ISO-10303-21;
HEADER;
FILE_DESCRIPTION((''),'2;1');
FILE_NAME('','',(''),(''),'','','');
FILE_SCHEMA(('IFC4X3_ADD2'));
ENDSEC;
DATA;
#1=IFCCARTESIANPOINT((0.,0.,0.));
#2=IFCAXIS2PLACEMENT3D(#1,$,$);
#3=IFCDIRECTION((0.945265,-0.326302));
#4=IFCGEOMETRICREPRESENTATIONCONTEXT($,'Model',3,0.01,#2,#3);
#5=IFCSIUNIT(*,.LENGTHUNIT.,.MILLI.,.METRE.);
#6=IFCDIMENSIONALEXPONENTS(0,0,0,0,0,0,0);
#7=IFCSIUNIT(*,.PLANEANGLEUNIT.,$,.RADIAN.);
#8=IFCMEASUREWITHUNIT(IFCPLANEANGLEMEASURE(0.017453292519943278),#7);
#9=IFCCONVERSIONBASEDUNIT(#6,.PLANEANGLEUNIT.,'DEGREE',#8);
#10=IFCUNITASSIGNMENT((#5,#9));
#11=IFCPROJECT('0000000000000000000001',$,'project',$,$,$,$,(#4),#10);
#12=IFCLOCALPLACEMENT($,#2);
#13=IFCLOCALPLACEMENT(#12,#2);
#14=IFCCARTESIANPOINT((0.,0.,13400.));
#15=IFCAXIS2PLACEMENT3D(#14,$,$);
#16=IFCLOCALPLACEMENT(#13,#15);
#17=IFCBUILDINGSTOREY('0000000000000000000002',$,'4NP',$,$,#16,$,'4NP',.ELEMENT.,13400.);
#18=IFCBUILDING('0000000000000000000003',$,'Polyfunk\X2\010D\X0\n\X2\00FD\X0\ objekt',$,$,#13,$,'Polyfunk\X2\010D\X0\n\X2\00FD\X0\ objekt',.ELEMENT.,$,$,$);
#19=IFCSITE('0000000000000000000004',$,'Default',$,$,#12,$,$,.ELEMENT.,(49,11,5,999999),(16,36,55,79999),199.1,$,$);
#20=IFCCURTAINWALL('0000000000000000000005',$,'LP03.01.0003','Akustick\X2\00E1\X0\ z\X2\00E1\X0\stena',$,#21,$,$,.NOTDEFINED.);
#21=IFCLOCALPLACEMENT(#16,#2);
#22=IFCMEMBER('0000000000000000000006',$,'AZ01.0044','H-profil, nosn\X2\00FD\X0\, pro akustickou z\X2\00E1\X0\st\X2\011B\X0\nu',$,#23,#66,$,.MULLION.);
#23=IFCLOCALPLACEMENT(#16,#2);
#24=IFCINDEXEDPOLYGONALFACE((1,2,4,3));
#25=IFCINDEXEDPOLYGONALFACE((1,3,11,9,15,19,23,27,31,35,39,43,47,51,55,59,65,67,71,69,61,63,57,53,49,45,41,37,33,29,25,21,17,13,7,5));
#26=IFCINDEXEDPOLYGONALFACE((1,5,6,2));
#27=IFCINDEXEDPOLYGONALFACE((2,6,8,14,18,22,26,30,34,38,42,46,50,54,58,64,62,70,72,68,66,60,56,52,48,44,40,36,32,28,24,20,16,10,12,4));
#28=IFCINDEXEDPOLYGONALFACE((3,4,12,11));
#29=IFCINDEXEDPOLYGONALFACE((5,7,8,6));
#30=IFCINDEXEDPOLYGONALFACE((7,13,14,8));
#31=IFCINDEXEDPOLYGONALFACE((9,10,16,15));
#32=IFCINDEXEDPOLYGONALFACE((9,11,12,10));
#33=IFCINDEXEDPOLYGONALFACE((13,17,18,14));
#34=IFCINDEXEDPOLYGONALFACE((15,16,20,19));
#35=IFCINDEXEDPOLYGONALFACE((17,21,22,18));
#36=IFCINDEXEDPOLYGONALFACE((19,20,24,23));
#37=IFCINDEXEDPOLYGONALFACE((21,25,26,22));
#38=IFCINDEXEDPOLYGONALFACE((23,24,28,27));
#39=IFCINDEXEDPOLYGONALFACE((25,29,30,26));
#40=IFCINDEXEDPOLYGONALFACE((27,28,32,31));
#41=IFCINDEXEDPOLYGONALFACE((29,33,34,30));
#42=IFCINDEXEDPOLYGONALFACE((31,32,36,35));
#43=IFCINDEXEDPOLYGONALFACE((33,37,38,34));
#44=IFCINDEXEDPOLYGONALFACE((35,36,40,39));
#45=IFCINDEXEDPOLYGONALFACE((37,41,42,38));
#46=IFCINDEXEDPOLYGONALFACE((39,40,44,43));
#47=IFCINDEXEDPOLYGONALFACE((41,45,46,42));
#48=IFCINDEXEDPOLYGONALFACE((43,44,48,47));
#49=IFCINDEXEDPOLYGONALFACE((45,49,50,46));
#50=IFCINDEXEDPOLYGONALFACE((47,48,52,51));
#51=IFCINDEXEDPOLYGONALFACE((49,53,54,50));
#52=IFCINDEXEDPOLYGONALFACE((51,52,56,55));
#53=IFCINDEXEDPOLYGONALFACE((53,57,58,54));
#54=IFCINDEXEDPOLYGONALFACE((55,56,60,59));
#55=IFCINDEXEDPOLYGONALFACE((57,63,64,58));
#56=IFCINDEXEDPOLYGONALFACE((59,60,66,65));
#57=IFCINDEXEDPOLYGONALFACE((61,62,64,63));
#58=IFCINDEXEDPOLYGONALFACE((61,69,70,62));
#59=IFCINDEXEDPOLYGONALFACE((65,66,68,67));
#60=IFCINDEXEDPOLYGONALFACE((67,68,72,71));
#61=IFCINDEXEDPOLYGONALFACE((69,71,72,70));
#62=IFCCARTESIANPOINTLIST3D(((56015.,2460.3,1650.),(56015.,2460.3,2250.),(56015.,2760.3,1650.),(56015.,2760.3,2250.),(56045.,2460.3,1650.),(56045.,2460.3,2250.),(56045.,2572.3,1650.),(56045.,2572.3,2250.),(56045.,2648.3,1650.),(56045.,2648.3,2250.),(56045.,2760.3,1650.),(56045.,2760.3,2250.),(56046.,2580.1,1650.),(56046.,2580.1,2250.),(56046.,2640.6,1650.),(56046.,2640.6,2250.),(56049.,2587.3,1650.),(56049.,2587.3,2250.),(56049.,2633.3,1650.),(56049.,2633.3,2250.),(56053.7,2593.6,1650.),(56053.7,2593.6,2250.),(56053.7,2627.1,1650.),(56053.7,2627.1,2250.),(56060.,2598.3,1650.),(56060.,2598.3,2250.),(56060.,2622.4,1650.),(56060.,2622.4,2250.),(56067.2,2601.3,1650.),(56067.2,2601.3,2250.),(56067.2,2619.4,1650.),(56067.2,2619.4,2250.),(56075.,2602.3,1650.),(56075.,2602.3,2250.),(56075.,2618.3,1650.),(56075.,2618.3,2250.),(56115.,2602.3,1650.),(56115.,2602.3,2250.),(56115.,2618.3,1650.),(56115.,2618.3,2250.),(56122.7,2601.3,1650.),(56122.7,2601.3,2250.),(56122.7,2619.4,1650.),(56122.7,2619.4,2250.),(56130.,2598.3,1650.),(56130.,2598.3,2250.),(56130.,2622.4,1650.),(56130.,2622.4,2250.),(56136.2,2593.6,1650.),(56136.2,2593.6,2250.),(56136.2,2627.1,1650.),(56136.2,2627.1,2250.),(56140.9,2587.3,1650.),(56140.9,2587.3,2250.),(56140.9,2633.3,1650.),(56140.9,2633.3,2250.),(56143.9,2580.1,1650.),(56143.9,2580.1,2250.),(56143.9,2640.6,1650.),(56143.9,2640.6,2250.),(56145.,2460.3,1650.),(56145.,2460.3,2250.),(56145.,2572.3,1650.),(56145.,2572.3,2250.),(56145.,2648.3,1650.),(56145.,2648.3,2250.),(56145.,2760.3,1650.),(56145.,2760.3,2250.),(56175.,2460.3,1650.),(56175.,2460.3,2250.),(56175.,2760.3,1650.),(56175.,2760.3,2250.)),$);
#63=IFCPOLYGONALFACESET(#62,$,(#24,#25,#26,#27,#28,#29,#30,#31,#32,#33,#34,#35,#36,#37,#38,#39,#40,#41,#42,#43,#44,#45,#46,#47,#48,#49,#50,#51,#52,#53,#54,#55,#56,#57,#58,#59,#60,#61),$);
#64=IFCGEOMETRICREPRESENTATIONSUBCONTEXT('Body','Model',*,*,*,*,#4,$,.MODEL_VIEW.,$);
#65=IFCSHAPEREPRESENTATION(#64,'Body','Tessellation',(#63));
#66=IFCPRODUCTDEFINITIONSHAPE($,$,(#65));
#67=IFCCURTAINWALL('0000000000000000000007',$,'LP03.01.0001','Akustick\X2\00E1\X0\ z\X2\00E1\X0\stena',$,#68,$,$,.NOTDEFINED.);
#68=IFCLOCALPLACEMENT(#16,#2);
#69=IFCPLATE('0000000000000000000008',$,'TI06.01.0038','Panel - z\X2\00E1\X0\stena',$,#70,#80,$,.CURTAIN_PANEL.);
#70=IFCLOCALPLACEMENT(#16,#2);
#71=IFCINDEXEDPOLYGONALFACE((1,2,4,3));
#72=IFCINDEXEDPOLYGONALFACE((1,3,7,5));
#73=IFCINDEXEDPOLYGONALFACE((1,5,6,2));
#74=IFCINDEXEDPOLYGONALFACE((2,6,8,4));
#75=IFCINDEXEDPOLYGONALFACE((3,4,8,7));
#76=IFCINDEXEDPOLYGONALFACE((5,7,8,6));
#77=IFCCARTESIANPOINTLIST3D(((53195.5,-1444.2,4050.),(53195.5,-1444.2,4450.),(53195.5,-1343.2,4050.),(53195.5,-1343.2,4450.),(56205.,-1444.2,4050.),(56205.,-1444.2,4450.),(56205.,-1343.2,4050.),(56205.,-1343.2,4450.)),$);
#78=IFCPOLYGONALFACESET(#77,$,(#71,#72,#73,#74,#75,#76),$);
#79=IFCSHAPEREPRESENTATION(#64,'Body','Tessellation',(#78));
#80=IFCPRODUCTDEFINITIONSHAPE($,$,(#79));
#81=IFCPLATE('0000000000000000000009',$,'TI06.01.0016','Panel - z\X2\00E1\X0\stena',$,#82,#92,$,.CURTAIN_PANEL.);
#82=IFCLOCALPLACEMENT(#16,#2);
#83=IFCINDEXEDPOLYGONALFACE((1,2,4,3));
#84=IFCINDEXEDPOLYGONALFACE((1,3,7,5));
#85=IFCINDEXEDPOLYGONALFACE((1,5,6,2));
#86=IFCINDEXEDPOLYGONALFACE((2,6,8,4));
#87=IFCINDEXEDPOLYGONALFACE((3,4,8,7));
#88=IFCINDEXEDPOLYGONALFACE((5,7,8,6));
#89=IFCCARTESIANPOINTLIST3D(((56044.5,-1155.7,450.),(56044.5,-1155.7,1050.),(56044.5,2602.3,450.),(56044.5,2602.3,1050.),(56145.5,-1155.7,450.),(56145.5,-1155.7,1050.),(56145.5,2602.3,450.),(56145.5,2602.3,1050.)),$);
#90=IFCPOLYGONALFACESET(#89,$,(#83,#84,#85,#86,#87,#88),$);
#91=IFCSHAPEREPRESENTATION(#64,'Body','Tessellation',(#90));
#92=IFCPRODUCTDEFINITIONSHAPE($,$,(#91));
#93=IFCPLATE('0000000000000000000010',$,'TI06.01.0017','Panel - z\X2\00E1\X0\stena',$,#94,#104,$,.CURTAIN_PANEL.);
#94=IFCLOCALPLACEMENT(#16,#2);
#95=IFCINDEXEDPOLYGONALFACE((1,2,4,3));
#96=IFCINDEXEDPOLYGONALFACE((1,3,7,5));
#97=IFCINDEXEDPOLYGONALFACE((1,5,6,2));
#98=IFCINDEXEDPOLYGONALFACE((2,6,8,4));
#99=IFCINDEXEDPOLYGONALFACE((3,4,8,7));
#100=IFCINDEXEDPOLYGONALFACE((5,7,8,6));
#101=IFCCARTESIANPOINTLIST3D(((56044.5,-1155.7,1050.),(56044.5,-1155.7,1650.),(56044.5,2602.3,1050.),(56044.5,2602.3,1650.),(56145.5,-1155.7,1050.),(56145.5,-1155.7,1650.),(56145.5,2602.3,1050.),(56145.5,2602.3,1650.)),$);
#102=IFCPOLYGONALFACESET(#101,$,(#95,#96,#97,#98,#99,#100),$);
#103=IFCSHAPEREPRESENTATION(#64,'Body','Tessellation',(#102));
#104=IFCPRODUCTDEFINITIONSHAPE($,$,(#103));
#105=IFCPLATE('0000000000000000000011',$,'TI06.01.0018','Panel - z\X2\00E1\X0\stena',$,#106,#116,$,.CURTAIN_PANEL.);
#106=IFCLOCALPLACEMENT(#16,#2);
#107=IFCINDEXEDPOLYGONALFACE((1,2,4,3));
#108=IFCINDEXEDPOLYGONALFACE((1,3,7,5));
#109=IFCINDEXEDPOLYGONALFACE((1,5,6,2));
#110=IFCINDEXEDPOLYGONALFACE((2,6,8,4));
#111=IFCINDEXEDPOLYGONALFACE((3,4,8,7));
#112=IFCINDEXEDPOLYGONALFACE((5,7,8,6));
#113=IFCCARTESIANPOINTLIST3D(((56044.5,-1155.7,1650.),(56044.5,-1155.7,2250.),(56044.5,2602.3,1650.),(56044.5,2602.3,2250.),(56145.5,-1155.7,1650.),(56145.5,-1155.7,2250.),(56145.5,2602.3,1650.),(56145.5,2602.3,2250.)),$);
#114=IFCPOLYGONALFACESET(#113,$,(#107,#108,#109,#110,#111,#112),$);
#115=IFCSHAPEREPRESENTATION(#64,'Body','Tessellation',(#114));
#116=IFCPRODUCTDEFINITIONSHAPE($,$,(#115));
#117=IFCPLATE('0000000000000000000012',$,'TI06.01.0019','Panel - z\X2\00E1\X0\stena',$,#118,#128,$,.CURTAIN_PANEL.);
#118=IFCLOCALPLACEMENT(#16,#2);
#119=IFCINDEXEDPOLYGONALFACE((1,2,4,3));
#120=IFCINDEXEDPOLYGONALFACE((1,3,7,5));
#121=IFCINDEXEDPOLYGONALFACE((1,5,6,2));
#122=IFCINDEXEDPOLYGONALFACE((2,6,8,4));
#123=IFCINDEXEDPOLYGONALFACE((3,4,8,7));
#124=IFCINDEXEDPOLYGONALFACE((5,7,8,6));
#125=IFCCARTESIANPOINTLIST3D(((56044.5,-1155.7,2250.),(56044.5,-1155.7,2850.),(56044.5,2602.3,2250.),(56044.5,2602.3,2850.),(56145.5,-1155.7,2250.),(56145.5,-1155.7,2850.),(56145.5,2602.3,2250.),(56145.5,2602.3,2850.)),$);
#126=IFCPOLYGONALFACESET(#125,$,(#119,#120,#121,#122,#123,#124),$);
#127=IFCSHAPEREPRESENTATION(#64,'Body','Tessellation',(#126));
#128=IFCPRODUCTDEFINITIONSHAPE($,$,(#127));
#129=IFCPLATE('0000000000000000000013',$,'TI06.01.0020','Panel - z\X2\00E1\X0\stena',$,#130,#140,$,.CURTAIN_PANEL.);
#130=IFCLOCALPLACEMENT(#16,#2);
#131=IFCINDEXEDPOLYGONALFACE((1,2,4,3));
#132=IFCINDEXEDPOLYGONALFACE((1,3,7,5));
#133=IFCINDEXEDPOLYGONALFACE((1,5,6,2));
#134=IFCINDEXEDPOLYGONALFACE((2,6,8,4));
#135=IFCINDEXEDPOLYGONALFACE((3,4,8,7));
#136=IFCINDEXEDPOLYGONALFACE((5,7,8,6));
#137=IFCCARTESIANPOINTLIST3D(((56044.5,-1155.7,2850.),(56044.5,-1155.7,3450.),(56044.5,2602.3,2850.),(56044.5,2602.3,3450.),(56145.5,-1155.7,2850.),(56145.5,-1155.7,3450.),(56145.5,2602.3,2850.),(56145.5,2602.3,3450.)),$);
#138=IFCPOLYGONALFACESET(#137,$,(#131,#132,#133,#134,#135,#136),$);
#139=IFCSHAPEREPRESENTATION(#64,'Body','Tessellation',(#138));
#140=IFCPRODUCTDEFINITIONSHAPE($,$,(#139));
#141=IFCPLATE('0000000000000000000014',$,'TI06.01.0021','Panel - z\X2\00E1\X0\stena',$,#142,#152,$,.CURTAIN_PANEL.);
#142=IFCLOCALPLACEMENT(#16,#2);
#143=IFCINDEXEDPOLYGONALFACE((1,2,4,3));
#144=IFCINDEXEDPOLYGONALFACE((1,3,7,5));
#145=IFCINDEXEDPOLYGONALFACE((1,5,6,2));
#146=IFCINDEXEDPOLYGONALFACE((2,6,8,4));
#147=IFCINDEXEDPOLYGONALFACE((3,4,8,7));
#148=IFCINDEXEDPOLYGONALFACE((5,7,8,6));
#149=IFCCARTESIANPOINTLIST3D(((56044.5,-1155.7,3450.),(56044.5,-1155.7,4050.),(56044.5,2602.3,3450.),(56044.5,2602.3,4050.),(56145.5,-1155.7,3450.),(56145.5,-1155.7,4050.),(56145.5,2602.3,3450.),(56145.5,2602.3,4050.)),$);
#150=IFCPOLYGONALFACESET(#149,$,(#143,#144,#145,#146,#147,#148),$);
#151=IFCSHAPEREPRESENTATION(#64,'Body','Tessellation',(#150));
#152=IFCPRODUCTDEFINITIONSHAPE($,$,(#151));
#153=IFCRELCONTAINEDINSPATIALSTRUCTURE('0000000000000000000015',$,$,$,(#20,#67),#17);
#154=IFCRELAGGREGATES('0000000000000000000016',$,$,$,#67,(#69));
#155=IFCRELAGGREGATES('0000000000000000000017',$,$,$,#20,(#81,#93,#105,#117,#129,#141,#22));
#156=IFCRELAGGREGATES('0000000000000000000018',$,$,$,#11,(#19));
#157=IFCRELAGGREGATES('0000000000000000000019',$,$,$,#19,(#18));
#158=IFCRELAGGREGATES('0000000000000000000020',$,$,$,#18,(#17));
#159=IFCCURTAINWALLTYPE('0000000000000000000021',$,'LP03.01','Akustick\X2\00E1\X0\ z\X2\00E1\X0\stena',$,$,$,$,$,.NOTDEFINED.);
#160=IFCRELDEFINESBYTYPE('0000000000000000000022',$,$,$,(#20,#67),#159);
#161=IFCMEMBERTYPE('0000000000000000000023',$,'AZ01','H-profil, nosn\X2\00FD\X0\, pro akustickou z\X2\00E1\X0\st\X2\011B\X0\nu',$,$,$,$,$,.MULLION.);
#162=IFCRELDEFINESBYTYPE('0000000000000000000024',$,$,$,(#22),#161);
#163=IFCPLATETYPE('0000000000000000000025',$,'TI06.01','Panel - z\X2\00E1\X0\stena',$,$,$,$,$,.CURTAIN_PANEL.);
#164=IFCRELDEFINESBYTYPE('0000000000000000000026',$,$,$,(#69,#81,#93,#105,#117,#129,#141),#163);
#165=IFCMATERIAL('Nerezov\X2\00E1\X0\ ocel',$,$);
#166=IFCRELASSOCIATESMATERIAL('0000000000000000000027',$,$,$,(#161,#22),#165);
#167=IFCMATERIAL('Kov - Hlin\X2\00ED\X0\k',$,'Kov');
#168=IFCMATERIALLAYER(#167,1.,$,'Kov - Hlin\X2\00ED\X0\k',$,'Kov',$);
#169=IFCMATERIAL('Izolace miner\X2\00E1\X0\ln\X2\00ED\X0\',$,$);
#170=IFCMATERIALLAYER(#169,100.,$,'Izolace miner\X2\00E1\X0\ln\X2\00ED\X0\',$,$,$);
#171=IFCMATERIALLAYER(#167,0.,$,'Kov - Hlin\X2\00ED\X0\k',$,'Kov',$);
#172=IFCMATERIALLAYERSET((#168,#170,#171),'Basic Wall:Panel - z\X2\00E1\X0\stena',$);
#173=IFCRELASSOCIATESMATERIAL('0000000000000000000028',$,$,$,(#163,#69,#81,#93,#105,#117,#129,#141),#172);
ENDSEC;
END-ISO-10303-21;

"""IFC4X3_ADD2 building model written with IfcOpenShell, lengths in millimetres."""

from ifc_helpers import new_model, entity, si_unit, converted_unit, direction, frame, frame_2d, origin, place, context, subcontext, project, spatial, polyline, circle_curve, parameter, trimmed, segment, composite_curve, rectangle, outline, extrude, source, transform, mapped, material, layer, layer_set, layer_usage, material_profile, profile_set, profile_usage, type_object, element, aggregate, save


model = new_model("IFC4X3_ADD2")

# Units and contexts
model_context = context("Model", 3, precision=0.01, world=origin(), true_north=direction((0.945265, -0.326302)))
body_context = subcontext(model_context, "Body", "Model", "MODEL_VIEW")
ifc_project = project(units=[si_unit("LENGTHUNIT", "METRE", prefix="MILLI"), converted_unit("PLANEANGLEUNIT", "DEGREE", entity("IfcPlaneAngleMeasure", 0.017453292519943278), si_unit("PLANEANGLEUNIT", "RADIAN"), dimensions=[0, 0, 0, 0, 0, 0, 0])], contexts=[model_context])

# Site, building, storey
site_placement = place(None, origin())
site = spatial("IfcSite", under=ifc_project, at=site_placement, Name="Default", CompositionType="ELEMENT", RefLatitude=(49, 11, 5, 999999), RefLongitude=(16, 36, 55, 79999), RefElevation=199.1)
building_placement = place(site_placement, origin())
building = spatial("IfcBuilding", under=site, at=building_placement, Name="Polyfunkčný objekt", LongName="Polyfunkčný objekt", CompositionType="ELEMENT")
storey_placement = place(building_placement, frame((0.0, 0.0, 13400.0)))
storey = spatial("IfcBuildingStorey", under=building, at=storey_placement, Name="4NP", LongName="4NP", CompositionType="ELEMENT", Elevation=13400.0)

# Curtain wall, member
curtain_wall_type = type_object("IfcCurtainWallType", Name="LP03.01", Description="Akustická zástena", PredefinedType="NOTDEFINED")
curtain_wall_1_placement = place(storey_placement, frame((0.0, 0.0, -13400.0)))
curtain_wall_1 = element("IfcCurtainWall", 1, at=curtain_wall_1_placement, inside=storey, type_object=curtain_wall_type, Name="LP03.01.0003", Description="Akustická zástena", PredefinedType="NOTDEFINED")
ifc_material_1 = material(Name="Nerezová ocel")
ifc_material_profile = material_profile(ifc_material_1, outline(composite_curve([segment(polyline([(50.0, -150.0), (80.0, -150.0)]), True, "CONTINUOUS"), segment(polyline([(80.0, -150.0), (80.0, 150.0)]), True, "CONTINUOUS"), segment(polyline([(80.0, 150.0), (50.0, 150.0)]), True, "CONTINUOUS"), segment(polyline([(50.0, 150.0), (50.0, 38.0)]), True, "CONTINUOUS"), segment(trimmed(circle_curve(frame_2d((20.0, 38.0), x_axis=(0.0, 1.0)), 30.0), [parameter(180.0)], [parameter(270.0)], True, "PARAMETER"), False, "CONTINUOUS"), segment(polyline([(20.0, 8.0), (-20.0, 8.0)]), True, "CONTINUOUS"), segment(trimmed(circle_curve(frame_2d((-20.0, 38.0), x_axis=(0.0, 1.0)), 30.0), [parameter(90.0)], [parameter(180.0)], True, "PARAMETER"), False, "CONTINUOUS"), segment(polyline([(-50.0, 38.0), (-50.0, 150.0)]), True, "CONTINUOUS"), segment(polyline([(-50.0, 150.0), (-80.0, 150.0)]), True, "CONTINUOUS"), segment(polyline([(-80.0, 150.0), (-80.0, -150.0)]), True, "CONTINUOUS"), segment(polyline([(-80.0, -150.0), (-50.0, -150.0)]), True, "CONTINUOUS"), segment(polyline([(-50.0, -150.0), (-50.0, -38.0)]), True, "CONTINUOUS"), segment(trimmed(circle_curve(frame_2d((-20.0, -38.0), x_axis=(0.0, 1.0)), 30.0), [parameter(0.0)], [parameter(90.0)], True, "PARAMETER"), False, "CONTINUOUS"), segment(polyline([(-20.0, -8.0), (20.0, -8.0)]), True, "CONTINUOUS"), segment(trimmed(circle_curve(frame_2d((20.0, -38.0), x_axis=(0.0, 1.0)), 30.0), [parameter(270.0)], [parameter(0.0)], True, "PARAMETER"), False, "CONTINUOUS"), segment(polyline([(50.0, -38.0), (50.0, -150.0)]), True, "CONTINUOUS")], self_intersect=False)), Name="Profil zástena")
ifc_profile_set = profile_set([ifc_material_profile], Name="Profil zástena")
ifc_profile_usage = profile_usage(ifc_profile_set)
member_type = type_object("IfcMemberType", Name="AZ01", Description="H-profil, nosný, pro akustickou zástěnu", PredefinedType="MULLION", material=ifc_profile_set)
shared_shape_1 = source(origin(), body_context, "Body", "SweptSolid", [
    extrude(outline(composite_curve([segment(polyline([(-150.0, -50.0), (-150.0, -80.0)]), True, "CONTINUOUS"), segment(polyline([(-150.0, -80.0), (150.0, -80.0)]), True, "CONTINUOUS"), segment(polyline([(150.0, -80.0), (150.0, -50.0)]), True, "CONTINUOUS"), segment(polyline([(150.0, -50.0), (38.0, -50.0)]), True, "CONTINUOUS"), segment(trimmed(circle_curve(frame_2d((38.0, -20.0), x_axis=(1.0, 0.0)), 30.0), [parameter(180.0)], [parameter(270.0)], True, "PARAMETER"), False, "CONTINUOUS"), segment(polyline([(8.0, -20.0), (8.0, 20.0)]), True, "CONTINUOUS"), segment(trimmed(circle_curve(frame_2d((38.0, 20.0), x_axis=(1.0, 0.0)), 30.0), [parameter(90.0)], [parameter(180.0)], True, "PARAMETER"), False, "CONTINUOUS"), segment(polyline([(38.0, 50.0), (150.0, 50.0)]), True, "CONTINUOUS"), segment(polyline([(150.0, 50.0), (150.0, 80.0)]), True, "CONTINUOUS"), segment(polyline([(150.0, 80.0), (-150.0, 80.0)]), True, "CONTINUOUS"), segment(polyline([(-150.0, 80.0), (-150.0, 50.0)]), True, "CONTINUOUS"), segment(polyline([(-150.0, 50.0), (-38.0, 50.0)]), True, "CONTINUOUS"), segment(trimmed(circle_curve(frame_2d((-38.0, 20.0), x_axis=(1.0, 0.0)), 30.0), [parameter(0.0)], [parameter(90.0)], True, "PARAMETER"), False, "CONTINUOUS"), segment(polyline([(-8.0, 20.0), (-8.0, -20.0)]), True, "CONTINUOUS"), segment(trimmed(circle_curve(frame_2d((-38.0, -20.0), x_axis=(1.0, 0.0)), 30.0), [parameter(270.0)], [parameter(0.0)], True, "PARAMETER"), False, "CONTINUOUS"), segment(polyline([(-38.0, -50.0), (-150.0, -50.0)]), True, "CONTINUOUS")], self_intersect=False)), frame((0.0, 0.0, -600.0), z_axis=(0.0, 0.0, -1.0), x_axis=(1.0, 0.0, 0.0)), (0.0, 0.0, -1.0), 600.0),
])
member_1_placement = place(curtain_wall_1_placement, frame((56095.0, 2610.3, 15050.0), z_axis=(0.0, 0.0, -1.0), x_axis=(0.0, 1.0, 0.0)))
member_1 = element("IfcMember", 2, at=member_1_placement, type_object=member_type, material=ifc_profile_usage, Name="AZ01.0044", Description="H-profil, nosný, pro akustickou zástěnu", PredefinedType="MULLION", context=body_context, shape_type="MappedRepresentation", body=[
    mapped(shared_shape_1, transform((0.0, 0.0, 0.0), scale=1.0)),
])

# Curtain wall, plate
curtain_wall_2_placement = place(storey_placement, frame((0.0, 0.0, -13400.0)))
curtain_wall_2 = element("IfcCurtainWall", 3, at=curtain_wall_2_placement, inside=storey, type_object=curtain_wall_type, Name="LP03.01.0001", Description="Akustická zástena", PredefinedType="NOTDEFINED")
ifc_material_2 = material(Name="Kov - Hliník", Category="Kov")
ifc_layer_1 = layer(ifc_material_2, 1.0, Name="Kov - Hliník", Category="Kov")
ifc_material_3 = material(Name="Izolace minerální")
ifc_layer_2 = layer(ifc_material_3, 100.0, Name="Izolace minerální")
ifc_layer_3 = layer(ifc_material_2, 0.0, Name="Kov - Hliník", Category="Kov")
ifc_layer_set_1 = layer_set([ifc_layer_1, ifc_layer_2, ifc_layer_3], Name="Basic Wall:Panel - zástena")
ifc_layer_usage_1 = layer_usage(ifc_layer_set_1, "AXIS2", "POSITIVE", -50.5)
plate_type = type_object("IfcPlateType", Name="TI06.01", Description="Panel - zástena", PredefinedType="CURTAIN_PANEL", material=ifc_layer_set_1)
plate_1_placement = place(storey_placement, frame((53195.5, -1393.7, 4050.0)))
plate_1 = element("IfcPlate", 4, at=plate_1_placement, type_object=plate_type, material=ifc_layer_usage_1, Name="TI06.01.0038", Description="Panel - zástena", PredefinedType="CURTAIN_PANEL", context=body_context, shape_type="SweptSolid", body=[
    extrude(rectangle(XDim=101.0, YDim=3009.5, at=frame_2d((0.0, 0.0), x_axis=(1.0, 0.0))), frame((1504.7, 0.0, 0.0), z_axis=(0.0, 0.0, 1.0), x_axis=(0.0, 1.0, 0.0)), (0.0, 0.0, 1.0), 400.0),
])
aggregate(curtain_wall_2, [plate_1])

# Plates
ifc_layer_usage_2 = layer_usage(ifc_layer_set_1, "AXIS2", "NEGATIVE", 50.5)
plate_2_placement = place(storey_placement, frame((56095.0, -1155.7, 450.0), z_axis=(0.0, 0.0, 1.0), x_axis=(0.0, 1.0, 0.0)))
plate_2 = element("IfcPlate", 5, at=plate_2_placement, type_object=plate_type, material=ifc_layer_usage_2, Name="TI06.01.0016", Description="Panel - zástena", PredefinedType="CURTAIN_PANEL", context=body_context, shape_type="SweptSolid", body=[
    extrude(rectangle(XDim=101.0, YDim=3758.1, at=frame_2d((0.0, 0.0), x_axis=(1.0, 0.0))), frame((1879.0, 0.0, 0.0), z_axis=(0.0, 0.0, 1.0), x_axis=(0.0, 1.0, 0.0)), (0.0, 0.0, 1.0), 600.0),
])
ifc_layer_usage_3 = layer_usage(ifc_layer_set_1, "AXIS2", "NEGATIVE", 50.5)
plate_3_placement = place(storey_placement, frame((56095.0, -1155.7, 1050.0), z_axis=(0.0, 0.0, 1.0), x_axis=(0.0, 1.0, 0.0)))
plate_3 = element("IfcPlate", 6, at=plate_3_placement, type_object=plate_type, material=ifc_layer_usage_3, Name="TI06.01.0017", Description="Panel - zástena", PredefinedType="CURTAIN_PANEL", context=body_context, shape_type="SweptSolid", body=[
    extrude(rectangle(XDim=101.0, YDim=3758.1, at=frame_2d((0.0, 0.0), x_axis=(1.0, 0.0))), frame((1879.0, 0.0, 0.0), z_axis=(0.0, 0.0, 1.0), x_axis=(0.0, 1.0, 0.0)), (0.0, 0.0, 1.0), 600.0),
])
ifc_layer_usage_4 = layer_usage(ifc_layer_set_1, "AXIS2", "NEGATIVE", 50.5)
plate_4_placement = place(storey_placement, frame((56095.0, -1155.7, 1650.0), z_axis=(0.0, 0.0, 1.0), x_axis=(0.0, 1.0, 0.0)))
plate_4 = element("IfcPlate", 7, at=plate_4_placement, type_object=plate_type, material=ifc_layer_usage_4, Name="TI06.01.0018", Description="Panel - zástena", PredefinedType="CURTAIN_PANEL", context=body_context, shape_type="SweptSolid", body=[
    extrude(rectangle(XDim=101.0, YDim=3758.1, at=frame_2d((0.0, 0.0), x_axis=(1.0, 0.0))), frame((1879.0, 0.0, 0.0), z_axis=(0.0, 0.0, 1.0), x_axis=(0.0, 1.0, 0.0)), (0.0, 0.0, 1.0), 600.0),
])
ifc_layer_usage_5 = layer_usage(ifc_layer_set_1, "AXIS2", "NEGATIVE", 50.5)
plate_5_placement = place(storey_placement, frame((56095.0, -1155.7, 2250.0), z_axis=(0.0, 0.0, 1.0), x_axis=(0.0, 1.0, 0.0)))
plate_5 = element("IfcPlate", 8, at=plate_5_placement, type_object=plate_type, material=ifc_layer_usage_5, Name="TI06.01.0019", Description="Panel - zástena", PredefinedType="CURTAIN_PANEL", context=body_context, shape_type="SweptSolid", body=[
    extrude(rectangle(XDim=101.0, YDim=3758.1, at=frame_2d((0.0, 0.0), x_axis=(1.0, 0.0))), frame((1879.0, 0.0, 0.0), z_axis=(0.0, 0.0, 1.0), x_axis=(0.0, 1.0, 0.0)), (0.0, 0.0, 1.0), 600.0),
])
ifc_layer_usage_6 = layer_usage(ifc_layer_set_1, "AXIS2", "NEGATIVE", 50.5)
plate_6_placement = place(storey_placement, frame((56095.0, -1155.7, 2850.0), z_axis=(0.0, 0.0, 1.0), x_axis=(0.0, 1.0, 0.0)))
plate_6 = element("IfcPlate", 9, at=plate_6_placement, type_object=plate_type, material=ifc_layer_usage_6, Name="TI06.01.0020", Description="Panel - zástena", PredefinedType="CURTAIN_PANEL", context=body_context, shape_type="SweptSolid", body=[
    extrude(rectangle(XDim=101.0, YDim=3758.1, at=frame_2d((0.0, 0.0), x_axis=(1.0, 0.0))), frame((1879.0, 0.0, 0.0), z_axis=(0.0, 0.0, 1.0), x_axis=(0.0, 1.0, 0.0)), (0.0, 0.0, 1.0), 600.0),
])
ifc_layer_usage_7 = layer_usage(ifc_layer_set_1, "AXIS2", "NEGATIVE", 50.5)
plate_7_placement = place(storey_placement, frame((56095.0, -1155.7, 3450.0), z_axis=(0.0, 0.0, 1.0), x_axis=(0.0, 1.0, 0.0)))
plate_7 = element("IfcPlate", 10, at=plate_7_placement, type_object=plate_type, material=ifc_layer_usage_7, Name="TI06.01.0021", Description="Panel - zástena", PredefinedType="CURTAIN_PANEL", context=body_context, shape_type="SweptSolid", body=[
    extrude(rectangle(XDim=101.0, YDim=3758.1, at=frame_2d((0.0, 0.0), x_axis=(1.0, 0.0))), frame((1879.0, 0.0, 0.0), z_axis=(0.0, 0.0, 1.0), x_axis=(0.0, 1.0, 0.0)), (0.0, 0.0, 1.0), 600.0),
])
aggregate(curtain_wall_1, [plate_2, plate_3, plate_4, plate_5, plate_6, plate_7, member_1])

save(model, "model.ifc")
